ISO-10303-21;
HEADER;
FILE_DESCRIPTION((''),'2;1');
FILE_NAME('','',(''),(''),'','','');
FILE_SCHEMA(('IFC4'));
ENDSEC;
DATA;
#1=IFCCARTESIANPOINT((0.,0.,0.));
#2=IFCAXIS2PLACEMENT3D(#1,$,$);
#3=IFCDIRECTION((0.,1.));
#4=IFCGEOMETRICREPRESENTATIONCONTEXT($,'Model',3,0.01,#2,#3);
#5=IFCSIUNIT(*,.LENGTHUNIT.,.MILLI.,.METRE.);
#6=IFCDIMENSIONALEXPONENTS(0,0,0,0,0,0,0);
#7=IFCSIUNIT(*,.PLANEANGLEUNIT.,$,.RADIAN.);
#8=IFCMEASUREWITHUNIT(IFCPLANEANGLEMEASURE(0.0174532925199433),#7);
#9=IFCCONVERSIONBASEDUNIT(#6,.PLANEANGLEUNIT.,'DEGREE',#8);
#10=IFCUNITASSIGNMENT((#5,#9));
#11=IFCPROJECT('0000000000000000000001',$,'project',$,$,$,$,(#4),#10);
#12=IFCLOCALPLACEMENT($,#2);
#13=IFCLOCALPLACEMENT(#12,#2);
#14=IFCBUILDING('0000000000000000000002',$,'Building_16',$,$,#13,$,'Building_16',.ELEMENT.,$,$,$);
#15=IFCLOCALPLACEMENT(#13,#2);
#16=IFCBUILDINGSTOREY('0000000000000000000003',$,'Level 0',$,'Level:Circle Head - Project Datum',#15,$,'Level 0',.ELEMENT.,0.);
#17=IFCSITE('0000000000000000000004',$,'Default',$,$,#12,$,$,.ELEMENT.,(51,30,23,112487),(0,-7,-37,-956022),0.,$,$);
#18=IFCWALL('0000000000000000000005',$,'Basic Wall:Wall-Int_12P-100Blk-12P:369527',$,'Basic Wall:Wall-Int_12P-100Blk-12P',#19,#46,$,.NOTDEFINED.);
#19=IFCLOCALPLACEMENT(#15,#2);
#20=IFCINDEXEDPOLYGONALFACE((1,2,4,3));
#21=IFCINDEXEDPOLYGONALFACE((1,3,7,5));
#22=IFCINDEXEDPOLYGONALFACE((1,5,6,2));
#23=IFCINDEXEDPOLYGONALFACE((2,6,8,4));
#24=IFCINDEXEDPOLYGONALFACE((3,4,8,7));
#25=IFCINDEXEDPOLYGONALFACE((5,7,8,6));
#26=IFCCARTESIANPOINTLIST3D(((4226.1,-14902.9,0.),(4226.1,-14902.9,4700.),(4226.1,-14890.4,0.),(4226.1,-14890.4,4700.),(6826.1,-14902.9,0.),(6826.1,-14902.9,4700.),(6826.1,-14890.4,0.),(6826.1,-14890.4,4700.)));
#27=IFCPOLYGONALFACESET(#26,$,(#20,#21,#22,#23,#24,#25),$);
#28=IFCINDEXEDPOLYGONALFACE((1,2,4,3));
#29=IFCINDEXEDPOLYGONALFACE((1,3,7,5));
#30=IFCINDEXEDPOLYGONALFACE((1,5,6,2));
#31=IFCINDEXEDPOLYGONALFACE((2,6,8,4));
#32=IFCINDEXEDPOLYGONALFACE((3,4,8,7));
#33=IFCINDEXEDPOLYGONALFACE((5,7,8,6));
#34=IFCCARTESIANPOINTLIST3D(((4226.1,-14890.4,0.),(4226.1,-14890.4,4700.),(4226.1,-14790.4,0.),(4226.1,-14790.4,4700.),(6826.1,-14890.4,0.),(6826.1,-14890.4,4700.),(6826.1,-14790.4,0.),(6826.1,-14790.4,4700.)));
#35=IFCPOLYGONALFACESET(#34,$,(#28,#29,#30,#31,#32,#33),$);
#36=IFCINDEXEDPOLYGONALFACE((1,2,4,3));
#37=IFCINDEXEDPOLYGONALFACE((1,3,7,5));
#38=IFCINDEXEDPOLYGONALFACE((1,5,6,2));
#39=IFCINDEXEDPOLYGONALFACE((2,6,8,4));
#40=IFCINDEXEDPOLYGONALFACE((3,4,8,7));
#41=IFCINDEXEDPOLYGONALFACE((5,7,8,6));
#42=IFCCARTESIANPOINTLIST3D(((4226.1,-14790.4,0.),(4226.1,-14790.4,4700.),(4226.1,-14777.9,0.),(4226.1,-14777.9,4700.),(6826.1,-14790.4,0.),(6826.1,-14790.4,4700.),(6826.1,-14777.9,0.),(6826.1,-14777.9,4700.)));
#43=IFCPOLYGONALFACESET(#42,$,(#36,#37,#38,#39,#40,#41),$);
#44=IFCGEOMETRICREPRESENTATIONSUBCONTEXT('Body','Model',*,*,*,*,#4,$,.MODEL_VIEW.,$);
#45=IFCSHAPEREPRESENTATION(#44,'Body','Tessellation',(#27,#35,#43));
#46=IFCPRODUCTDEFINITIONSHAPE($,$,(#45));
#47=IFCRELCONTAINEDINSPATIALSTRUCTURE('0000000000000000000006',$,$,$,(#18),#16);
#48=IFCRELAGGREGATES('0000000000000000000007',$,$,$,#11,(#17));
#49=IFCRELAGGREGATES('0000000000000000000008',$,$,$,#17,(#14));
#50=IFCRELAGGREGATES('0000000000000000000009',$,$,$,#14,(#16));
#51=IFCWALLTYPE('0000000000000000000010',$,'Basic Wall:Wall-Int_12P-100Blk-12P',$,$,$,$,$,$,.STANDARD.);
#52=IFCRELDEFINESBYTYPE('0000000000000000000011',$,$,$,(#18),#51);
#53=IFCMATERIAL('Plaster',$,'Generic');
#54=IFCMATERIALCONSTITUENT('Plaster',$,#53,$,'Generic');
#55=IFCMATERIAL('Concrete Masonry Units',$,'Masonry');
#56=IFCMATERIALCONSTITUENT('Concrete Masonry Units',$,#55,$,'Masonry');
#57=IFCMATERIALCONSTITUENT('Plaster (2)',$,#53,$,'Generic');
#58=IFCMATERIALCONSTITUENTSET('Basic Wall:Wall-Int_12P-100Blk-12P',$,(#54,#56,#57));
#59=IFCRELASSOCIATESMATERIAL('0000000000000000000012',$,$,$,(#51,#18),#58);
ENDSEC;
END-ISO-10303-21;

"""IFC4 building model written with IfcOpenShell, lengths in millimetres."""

from ifc_helpers import new_model, entity, si_unit, converted_unit, direction, frame, origin, place, context, subcontext, project, spatial, indexed_curve, outline, extrude, material, constituent, constituent_set, type_object, element, save


model = new_model("IFC4")

# Units and contexts
model_context = context("Model", 3, precision=0.01, world=origin(), true_north=direction((0.0, 1.0)))
body_context = subcontext(model_context, "Body", "Model", "MODEL_VIEW")
ifc_project = project(units=[si_unit("LENGTHUNIT", "METRE", prefix="MILLI"), converted_unit("PLANEANGLEUNIT", "DEGREE", entity("IfcPlaneAngleMeasure", 0.0174532925199433), si_unit("PLANEANGLEUNIT", "RADIAN"), dimensions=[0, 0, 0, 0, 0, 0, 0])], contexts=[model_context])

# Site, building, storey
site_placement = place(None, origin())
site = spatial("IfcSite", under=ifc_project, at=site_placement, Name="Default", CompositionType="ELEMENT", RefLatitude=(51, 30, 23, 112487), RefLongitude=(0, -7, -37, -956022), RefElevation=0.0)
building_placement = place(site_placement, origin())
building = spatial("IfcBuilding", under=site, at=building_placement, Name="Building_16", LongName="Building_16", CompositionType="ELEMENT")
storey_placement = place(building_placement, origin())
storey = spatial("IfcBuildingStorey", under=building, at=storey_placement, Name="Level 0", ObjectType="Level:Circle Head - Project Datum", LongName="Level 0", CompositionType="ELEMENT", Elevation=0.0)

# Shared definitions
ifc_material_1 = material(Name="Plaster", Category="Generic")
ifc_constituent_1 = constituent(ifc_material_1, Name="Plaster", Category="Generic")
ifc_material_2 = material(Name="Concrete Masonry Units", Category="Masonry")
ifc_constituent_2 = constituent(ifc_material_2, Name="Concrete Masonry Units", Category="Masonry")
ifc_constituent_3 = constituent(ifc_material_1, Name="Plaster (2)", Category="Generic")
ifc_constituent_set = constituent_set(constituents=[ifc_constituent_1, ifc_constituent_2, ifc_constituent_3], Name="Basic Wall:Wall-Int_12P-100Blk-12P")
wall_type = type_object("IfcWallType", Name="Basic Wall:Wall-Int_12P-100Blk-12P", PredefinedType="STANDARD", material=ifc_constituent_set)

# Wall
wall_1_placement = place(storey_placement, frame((4226.1, -14840.4, 0.0)))
element("IfcWall", 1, at=wall_1_placement, inside=storey, type_object=wall_type, material=ifc_constituent_set, Name="Basic Wall:Wall-Int_12P-100Blk-12P:369527", ObjectType="Basic Wall:Wall-Int_12P-100Blk-12P", PredefinedType="NOTDEFINED", context=body_context, shape_type="SweptSolid", body=[
    extrude(outline(indexed_curve([(-6.3, -1300.0), (6.2, -1300.0), (6.3, 1300.0), (-6.2, 1300.0), (-6.3, -1300.0)], self_intersect=False)), frame((1300.0, -56.3, 0.0), z_axis=(0.0, 0.0, 1.0), x_axis=(0.0, 1.0, 0.0)), (0.0, 0.0, 1.0), 4700.0),
    extrude(outline(indexed_curve([(-1300.0, -50.0), (1300.0, -50.0), (1300.0, 50.0), (-1300.0, 50.0), (-1300.0, -50.0)], self_intersect=False)), frame((1300.0, 0.0, 0.0)), (0.0, 0.0, 1.0), 4700.0),
    extrude(outline(indexed_curve([(-6.3, -1300.0), (6.2, -1300.0), (6.3, 1300.0), (-6.2, 1300.0), (-6.3, -1300.0)], self_intersect=False)), frame((1300.0, 56.3, 0.0), z_axis=(0.0, 0.0, 1.0), x_axis=(0.0, -1.0, 0.0)), (0.0, 0.0, 1.0), 4700.0),
])

save(model, "model.ifc")
